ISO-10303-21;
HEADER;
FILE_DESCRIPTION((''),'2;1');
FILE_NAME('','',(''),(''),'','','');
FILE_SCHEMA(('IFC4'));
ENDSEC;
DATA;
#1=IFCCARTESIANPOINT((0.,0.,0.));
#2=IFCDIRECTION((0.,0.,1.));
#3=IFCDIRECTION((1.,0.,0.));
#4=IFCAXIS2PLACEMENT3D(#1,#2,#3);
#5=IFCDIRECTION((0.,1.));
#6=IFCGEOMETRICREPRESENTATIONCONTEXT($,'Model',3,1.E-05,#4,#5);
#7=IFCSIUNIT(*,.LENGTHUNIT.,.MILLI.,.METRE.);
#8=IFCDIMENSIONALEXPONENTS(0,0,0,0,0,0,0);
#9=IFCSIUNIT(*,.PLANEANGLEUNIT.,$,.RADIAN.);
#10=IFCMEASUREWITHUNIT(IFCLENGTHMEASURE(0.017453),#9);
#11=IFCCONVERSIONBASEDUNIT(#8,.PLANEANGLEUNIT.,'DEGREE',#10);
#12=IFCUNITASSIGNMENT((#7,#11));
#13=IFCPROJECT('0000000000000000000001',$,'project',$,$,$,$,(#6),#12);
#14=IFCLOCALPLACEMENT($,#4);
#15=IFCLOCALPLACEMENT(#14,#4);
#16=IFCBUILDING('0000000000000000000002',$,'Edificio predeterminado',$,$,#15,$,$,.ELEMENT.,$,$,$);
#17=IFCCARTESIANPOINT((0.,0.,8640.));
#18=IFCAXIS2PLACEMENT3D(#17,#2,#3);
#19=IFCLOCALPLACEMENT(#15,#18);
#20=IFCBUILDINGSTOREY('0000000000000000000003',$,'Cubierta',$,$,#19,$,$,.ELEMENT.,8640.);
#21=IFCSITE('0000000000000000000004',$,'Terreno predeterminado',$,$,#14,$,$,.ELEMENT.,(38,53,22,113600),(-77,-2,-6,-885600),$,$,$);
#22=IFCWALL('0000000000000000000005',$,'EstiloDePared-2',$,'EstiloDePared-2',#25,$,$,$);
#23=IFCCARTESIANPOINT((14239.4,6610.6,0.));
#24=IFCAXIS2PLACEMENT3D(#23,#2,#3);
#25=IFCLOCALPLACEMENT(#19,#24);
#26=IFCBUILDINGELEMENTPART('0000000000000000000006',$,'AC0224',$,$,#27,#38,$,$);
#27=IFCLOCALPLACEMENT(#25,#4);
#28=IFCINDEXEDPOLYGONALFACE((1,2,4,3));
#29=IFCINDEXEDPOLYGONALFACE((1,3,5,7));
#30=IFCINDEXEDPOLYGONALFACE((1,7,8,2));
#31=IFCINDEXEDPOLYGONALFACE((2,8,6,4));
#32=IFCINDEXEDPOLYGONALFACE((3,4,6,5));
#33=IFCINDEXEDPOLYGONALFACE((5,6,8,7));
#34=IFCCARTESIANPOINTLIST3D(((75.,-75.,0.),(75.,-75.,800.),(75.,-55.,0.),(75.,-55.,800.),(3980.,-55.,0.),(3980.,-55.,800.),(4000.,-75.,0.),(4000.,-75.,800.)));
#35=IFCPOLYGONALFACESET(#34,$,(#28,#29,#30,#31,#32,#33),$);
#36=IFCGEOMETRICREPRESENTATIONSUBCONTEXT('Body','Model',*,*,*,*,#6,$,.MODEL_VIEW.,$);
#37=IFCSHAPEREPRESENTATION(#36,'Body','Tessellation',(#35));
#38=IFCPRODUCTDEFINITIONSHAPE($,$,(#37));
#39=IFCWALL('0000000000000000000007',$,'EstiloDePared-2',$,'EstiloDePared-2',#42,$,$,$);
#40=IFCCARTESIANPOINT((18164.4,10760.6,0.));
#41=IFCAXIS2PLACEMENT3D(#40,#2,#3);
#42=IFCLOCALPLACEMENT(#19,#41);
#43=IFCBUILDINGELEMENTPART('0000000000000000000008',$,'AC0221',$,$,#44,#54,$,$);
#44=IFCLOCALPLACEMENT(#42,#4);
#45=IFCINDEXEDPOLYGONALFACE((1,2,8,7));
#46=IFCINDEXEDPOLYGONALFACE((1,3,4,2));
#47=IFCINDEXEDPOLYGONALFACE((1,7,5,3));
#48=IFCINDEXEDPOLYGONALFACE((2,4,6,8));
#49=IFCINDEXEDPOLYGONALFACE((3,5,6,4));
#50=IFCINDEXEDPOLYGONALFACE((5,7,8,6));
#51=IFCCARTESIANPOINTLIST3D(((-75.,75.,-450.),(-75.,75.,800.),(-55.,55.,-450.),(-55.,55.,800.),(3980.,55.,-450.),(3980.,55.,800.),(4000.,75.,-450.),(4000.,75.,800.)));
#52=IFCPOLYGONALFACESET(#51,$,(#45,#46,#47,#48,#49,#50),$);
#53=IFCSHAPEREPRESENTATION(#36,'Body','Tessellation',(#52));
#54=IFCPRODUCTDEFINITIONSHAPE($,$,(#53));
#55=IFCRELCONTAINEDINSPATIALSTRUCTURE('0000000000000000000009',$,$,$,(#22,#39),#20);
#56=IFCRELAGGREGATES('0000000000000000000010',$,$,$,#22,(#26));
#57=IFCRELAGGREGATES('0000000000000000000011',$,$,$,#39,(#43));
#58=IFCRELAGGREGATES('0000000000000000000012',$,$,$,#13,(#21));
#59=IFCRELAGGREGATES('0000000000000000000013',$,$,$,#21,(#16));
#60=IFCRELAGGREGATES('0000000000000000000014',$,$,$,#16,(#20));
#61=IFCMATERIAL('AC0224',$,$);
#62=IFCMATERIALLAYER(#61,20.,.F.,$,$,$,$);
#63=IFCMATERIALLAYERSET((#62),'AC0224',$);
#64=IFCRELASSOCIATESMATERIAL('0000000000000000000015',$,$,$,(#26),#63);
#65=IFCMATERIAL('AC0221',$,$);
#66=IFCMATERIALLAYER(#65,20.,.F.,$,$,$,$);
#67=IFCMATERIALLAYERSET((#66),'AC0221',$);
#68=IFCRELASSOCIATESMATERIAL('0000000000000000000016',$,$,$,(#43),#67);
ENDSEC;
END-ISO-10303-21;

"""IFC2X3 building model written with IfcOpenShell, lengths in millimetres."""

from ifc_helpers import new_model, entity, si_unit, converted_unit, direction, frame, origin_with_axes, place, context, subcontext, project, spatial, polyline, outline, extrude, material, layer, layer_set, layer_usage, element, aggregate, save


model = new_model("IFC2X3")

# Units and contexts
model_context = context("Model", 3, precision=1e-05, world=origin_with_axes(), true_north=direction((0.0, 1.0)))
body_context = subcontext(model_context, "Body", "Model", "MODEL_VIEW")
ifc_project = project(units=[si_unit("LENGTHUNIT", "METRE", prefix="MILLI"), converted_unit("PLANEANGLEUNIT", "DEGREE", entity("IfcLengthMeasure", 0.017453), si_unit("PLANEANGLEUNIT", "RADIAN"), dimensions=[0, 0, 0, 0, 0, 0, 0])], contexts=[model_context])

# Site, building, storey
site_placement = place(None, origin_with_axes())
site = spatial("IfcSite", under=ifc_project, at=site_placement, Name="Terreno predeterminado", CompositionType="ELEMENT", RefLatitude=(38, 53, 22, 113600), RefLongitude=(-77, -2, -6, -885600))
building_placement = place(site_placement, origin_with_axes())
building = spatial("IfcBuilding", under=site, at=building_placement, Name="Edificio predeterminado", CompositionType="ELEMENT")
storey_placement = place(building_placement, frame((0.0, 0.0, 8640.0), z_axis=(0.0, 0.0, 1.0), x_axis=(1.0, 0.0, 0.0)))
storey = spatial("IfcBuildingStorey", under=building, at=storey_placement, Name="Cubierta", CompositionType="ELEMENT", Elevation=8640.0)

# Walls, building element parts
wall_1_placement = place(storey_placement, frame((14239.4, 6610.6, 0.0), z_axis=(0.0, 0.0, 1.0), x_axis=(1.0, 0.0, 0.0)))
wall_1 = element("IfcWall", 1, at=wall_1_placement, inside=storey, Name="EstiloDePared-2", ObjectType="EstiloDePared-2")
ifc_material_1 = material(Name="AC0224")
ifc_layer_1 = layer(ifc_material_1, 20.0, ventilated=False)
ifc_layer_set_1 = layer_set([ifc_layer_1], Name="AC0224")
ifc_layer_usage_1 = layer_usage(ifc_layer_set_1, "AXIS2", "NEGATIVE", 55.0)
building_element_part_1_placement = place(wall_1_placement, origin_with_axes())
building_element_part_1 = element("IfcBuildingElementPart", 2, at=building_element_part_1_placement, material=ifc_layer_usage_1, Name="AC0224", context=body_context, shape_type="SweptSolid", body=[
    extrude(outline(polyline([(3980.0, -55.0), (4000.0, -75.0), (75.0, -75.0), (75.0, -55.0), (3980.0, -55.0)])), origin_with_axes(), (0.0, 0.0, 1.0), 800.0),
])
aggregate(wall_1, [building_element_part_1])
wall_2_placement = place(storey_placement, frame((18164.4, 10760.6, 0.0), z_axis=(0.0, 0.0, 1.0), x_axis=(1.0, 0.0, 0.0)))
wall_2 = element("IfcWall", 3, at=wall_2_placement, inside=storey, Name="EstiloDePared-2", ObjectType="EstiloDePared-2")
ifc_material_2 = material(Name="AC0221")
ifc_layer_2 = layer(ifc_material_2, 20.0, ventilated=False)
ifc_layer_set_2 = layer_set([ifc_layer_2], Name="AC0221")
ifc_layer_usage_2 = layer_usage(ifc_layer_set_2, "AXIS2", "NEGATIVE", -75.0)
building_element_part_2_placement = place(wall_2_placement, origin_with_axes())
building_element_part_2 = element("IfcBuildingElementPart", 4, at=building_element_part_2_placement, material=ifc_layer_usage_2, Name="AC0221", context=body_context, shape_type="SweptSolid", body=[
    extrude(outline(polyline([(4000.0, 75.0), (3980.0, 55.0), (-55.0, 55.0), (-75.0, 75.0), (4000.0, 75.0)])), frame((0.0, 0.0, -450.0), z_axis=(0.0, 0.0, 1.0), x_axis=(1.0, 0.0, 0.0)), (0.0, 0.0, 1.0), 1250.0),
])
aggregate(wall_2, [building_element_part_2])

save(model, "model.ifc")
